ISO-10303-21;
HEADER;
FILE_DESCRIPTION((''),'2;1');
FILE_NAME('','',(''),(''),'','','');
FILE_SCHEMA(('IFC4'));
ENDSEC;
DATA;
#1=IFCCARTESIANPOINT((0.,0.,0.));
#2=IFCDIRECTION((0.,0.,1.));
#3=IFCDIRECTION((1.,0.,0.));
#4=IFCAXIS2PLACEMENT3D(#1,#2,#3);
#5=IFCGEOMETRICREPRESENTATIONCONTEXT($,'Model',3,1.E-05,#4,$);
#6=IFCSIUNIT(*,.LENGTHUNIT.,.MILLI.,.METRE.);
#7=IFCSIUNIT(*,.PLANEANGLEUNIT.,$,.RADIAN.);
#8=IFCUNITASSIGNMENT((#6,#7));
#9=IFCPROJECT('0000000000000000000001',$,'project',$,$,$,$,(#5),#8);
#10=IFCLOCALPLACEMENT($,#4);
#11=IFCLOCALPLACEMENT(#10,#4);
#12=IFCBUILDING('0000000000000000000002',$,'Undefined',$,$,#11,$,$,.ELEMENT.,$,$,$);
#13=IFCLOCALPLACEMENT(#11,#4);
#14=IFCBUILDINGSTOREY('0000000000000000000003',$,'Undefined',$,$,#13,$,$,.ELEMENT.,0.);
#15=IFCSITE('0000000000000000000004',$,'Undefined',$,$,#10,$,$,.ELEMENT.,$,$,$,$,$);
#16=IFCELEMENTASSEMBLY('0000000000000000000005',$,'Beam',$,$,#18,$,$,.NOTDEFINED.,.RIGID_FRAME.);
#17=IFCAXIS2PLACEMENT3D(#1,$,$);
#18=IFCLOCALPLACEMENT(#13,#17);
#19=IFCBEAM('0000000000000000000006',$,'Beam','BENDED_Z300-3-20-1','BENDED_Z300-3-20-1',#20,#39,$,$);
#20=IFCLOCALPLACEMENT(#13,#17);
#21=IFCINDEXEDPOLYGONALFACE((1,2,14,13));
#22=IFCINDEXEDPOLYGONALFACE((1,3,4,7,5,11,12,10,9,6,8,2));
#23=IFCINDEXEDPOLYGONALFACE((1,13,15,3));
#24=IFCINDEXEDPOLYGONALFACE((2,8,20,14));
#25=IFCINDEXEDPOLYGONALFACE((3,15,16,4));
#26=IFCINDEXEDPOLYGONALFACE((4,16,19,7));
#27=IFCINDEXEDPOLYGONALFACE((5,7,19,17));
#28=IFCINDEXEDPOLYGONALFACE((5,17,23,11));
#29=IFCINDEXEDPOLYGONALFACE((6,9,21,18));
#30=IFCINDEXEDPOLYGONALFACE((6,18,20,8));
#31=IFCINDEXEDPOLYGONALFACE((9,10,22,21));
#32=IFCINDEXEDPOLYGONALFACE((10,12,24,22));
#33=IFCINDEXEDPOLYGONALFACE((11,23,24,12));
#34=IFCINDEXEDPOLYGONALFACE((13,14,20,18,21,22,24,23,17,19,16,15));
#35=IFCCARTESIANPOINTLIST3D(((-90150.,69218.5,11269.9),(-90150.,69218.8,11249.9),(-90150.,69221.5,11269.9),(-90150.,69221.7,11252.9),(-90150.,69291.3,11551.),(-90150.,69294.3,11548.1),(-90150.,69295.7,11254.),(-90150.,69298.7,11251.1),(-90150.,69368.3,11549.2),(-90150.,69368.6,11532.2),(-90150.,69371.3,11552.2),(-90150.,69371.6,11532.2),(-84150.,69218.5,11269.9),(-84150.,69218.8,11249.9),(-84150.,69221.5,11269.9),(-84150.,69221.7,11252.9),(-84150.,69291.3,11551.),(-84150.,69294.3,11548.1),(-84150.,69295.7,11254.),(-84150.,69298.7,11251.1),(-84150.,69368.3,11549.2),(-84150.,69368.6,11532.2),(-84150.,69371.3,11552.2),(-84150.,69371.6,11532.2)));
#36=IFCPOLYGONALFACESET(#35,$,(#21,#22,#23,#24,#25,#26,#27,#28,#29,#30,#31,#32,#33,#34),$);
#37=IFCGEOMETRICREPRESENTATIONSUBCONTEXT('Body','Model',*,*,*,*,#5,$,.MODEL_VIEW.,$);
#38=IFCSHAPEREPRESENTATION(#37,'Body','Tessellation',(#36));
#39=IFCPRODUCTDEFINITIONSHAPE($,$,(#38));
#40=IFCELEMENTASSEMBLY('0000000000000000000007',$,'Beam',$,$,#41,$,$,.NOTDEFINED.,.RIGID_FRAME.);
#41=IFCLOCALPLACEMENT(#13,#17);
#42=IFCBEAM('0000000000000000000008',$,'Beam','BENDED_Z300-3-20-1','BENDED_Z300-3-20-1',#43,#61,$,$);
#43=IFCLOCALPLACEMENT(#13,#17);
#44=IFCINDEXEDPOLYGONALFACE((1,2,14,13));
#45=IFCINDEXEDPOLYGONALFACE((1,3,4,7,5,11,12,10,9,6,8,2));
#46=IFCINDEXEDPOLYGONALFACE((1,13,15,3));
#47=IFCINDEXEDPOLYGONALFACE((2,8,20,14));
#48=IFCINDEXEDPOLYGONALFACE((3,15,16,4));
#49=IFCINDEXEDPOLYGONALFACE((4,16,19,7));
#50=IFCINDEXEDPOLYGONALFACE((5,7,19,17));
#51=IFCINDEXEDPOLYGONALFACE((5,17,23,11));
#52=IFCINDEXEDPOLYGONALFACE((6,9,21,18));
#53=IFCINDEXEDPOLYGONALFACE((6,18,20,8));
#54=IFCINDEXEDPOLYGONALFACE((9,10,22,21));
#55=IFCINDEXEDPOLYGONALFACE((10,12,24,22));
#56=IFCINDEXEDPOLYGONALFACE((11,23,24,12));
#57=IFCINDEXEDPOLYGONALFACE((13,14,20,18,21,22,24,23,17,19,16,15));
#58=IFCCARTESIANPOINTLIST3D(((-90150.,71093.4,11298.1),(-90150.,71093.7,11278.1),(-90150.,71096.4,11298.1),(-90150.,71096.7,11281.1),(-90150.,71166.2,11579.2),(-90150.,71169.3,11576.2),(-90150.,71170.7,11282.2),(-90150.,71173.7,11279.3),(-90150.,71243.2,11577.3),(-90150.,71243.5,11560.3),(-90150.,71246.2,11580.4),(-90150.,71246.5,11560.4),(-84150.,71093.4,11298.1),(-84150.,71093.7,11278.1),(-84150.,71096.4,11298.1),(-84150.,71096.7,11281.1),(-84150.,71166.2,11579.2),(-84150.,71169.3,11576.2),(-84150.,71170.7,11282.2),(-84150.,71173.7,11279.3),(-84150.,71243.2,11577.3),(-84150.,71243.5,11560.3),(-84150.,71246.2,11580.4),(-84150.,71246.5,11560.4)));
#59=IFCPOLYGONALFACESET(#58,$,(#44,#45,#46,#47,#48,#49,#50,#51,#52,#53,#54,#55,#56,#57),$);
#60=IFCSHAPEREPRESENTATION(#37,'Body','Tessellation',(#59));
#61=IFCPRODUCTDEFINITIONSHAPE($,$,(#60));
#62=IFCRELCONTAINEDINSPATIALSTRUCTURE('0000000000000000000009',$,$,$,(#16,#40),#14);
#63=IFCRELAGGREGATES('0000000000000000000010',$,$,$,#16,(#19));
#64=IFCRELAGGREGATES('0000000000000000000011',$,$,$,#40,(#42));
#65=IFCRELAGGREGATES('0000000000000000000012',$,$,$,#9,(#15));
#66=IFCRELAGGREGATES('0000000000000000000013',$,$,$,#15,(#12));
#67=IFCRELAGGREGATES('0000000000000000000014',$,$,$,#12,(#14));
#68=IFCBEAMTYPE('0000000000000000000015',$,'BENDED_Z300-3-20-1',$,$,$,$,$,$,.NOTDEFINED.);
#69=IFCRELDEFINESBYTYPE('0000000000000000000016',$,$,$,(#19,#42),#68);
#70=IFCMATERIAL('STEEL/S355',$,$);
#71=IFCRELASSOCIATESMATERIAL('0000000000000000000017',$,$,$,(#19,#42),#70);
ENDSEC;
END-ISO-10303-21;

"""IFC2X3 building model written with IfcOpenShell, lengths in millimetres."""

from ifc_helpers import new_model, si_unit, frame, origin_with_axes, place, context, subcontext, project, spatial, polyline, outline, extrude, material, type_object, element, aggregate, save


model = new_model("IFC2X3")

# Units and contexts
model_context = context("Model", 3, precision=1e-05, world=origin_with_axes())
body_context = subcontext(model_context, "Body", "Model", "MODEL_VIEW")
ifc_project = project(units=[si_unit("LENGTHUNIT", "METRE", prefix="MILLI"), si_unit("PLANEANGLEUNIT", "RADIAN")], contexts=[model_context])

# Site, building, storey
site_placement = place(None, origin_with_axes())
site = spatial("IfcSite", under=ifc_project, at=site_placement, Name="Undefined", CompositionType="ELEMENT")
building_placement = place(site_placement, origin_with_axes())
building = spatial("IfcBuilding", under=site, at=building_placement, Name="Undefined", CompositionType="ELEMENT")
storey_placement = place(building_placement, origin_with_axes())
storey = spatial("IfcBuildingStorey", under=building, at=storey_placement, Name="Undefined", CompositionType="ELEMENT", Elevation=0.0)

# Shared definitions
ifc_material_1 = material(Name="STEEL/S355")

# Element assemblies, beams
beam_type_1 = type_object("IfcBeamType", Name="BENDED_Z300-3-20-1", PredefinedType="NOTDEFINED")
assembly_1_placement = place(storey_placement, origin_with_axes())
assembly_1 = element("IfcElementAssembly", 1, at=assembly_1_placement, inside=storey, Name="Beam", AssemblyPlace="NOTDEFINED", PredefinedType="RIGID_FRAME")
beam_1_placement = place(assembly_1_placement, frame((-84150.0, 69295.0, 11401.1), z_axis=(0.0, -0.014963, 0.999888), x_axis=(-1.0, 0.0, 0.0)))
beam_1 = element("IfcBeam", 2, at=beam_1_placement, type_object=beam_type_1, material=ifc_material_1, Name="Beam", Description="BENDED_Z300-3-20-1", ObjectType="BENDED_Z300-3-20-1", context=body_context, shape_type="SweptSolid", body=[
    extrude(outline(polyline([(1.5, -150.0), (-78.5, -150.0), (-78.5, -130.0), (-75.5, -130.0), (-75.5, -147.0), (-1.5, -147.0), (-1.5, 150.0), (78.5, 150.0), (78.5, 130.0), (75.5, 130.0), (75.5, 147.0), (1.5, 147.0), (1.5, -150.0)])), frame((6000.0, 0.0, 0.0), z_axis=(-1.0, 0.0, 0.0), x_axis=(0.0, -1.0, 0.0)), (0.0, 0.0, 1.0), 6000.0),
])
aggregate(assembly_1, [beam_1])
assembly_2_placement = place(storey_placement, origin_with_axes())
assembly_2 = element("IfcElementAssembly", 3, at=assembly_2_placement, inside=storey, Name="Beam", AssemblyPlace="NOTDEFINED", PredefinedType="RIGID_FRAME")
beam_2_placement = place(assembly_2_placement, frame((-84150.0, 71170.0, 11429.2), z_axis=(0.0, -0.014963, 0.999888), x_axis=(-1.0, 0.0, 0.0)))
beam_2 = element("IfcBeam", 4, at=beam_2_placement, type_object=beam_type_1, material=ifc_material_1, Name="Beam", Description="BENDED_Z300-3-20-1", ObjectType="BENDED_Z300-3-20-1", context=body_context, shape_type="SweptSolid", body=[
    extrude(outline(polyline([(1.5, -150.0), (-78.5, -150.0), (-78.5, -130.0), (-75.5, -130.0), (-75.5, -147.0), (-1.5, -147.0), (-1.5, 150.0), (78.5, 150.0), (78.5, 130.0), (75.5, 130.0), (75.5, 147.0), (1.5, 147.0), (1.5, -150.0)])), frame((6000.0, 0.0, 0.0), z_axis=(-1.0, 0.0, 0.0), x_axis=(0.0, -1.0, 0.0)), (0.0, 0.0, 1.0), 6000.0),
])
aggregate(assembly_2, [beam_2])

save(model, "model.ifc")
